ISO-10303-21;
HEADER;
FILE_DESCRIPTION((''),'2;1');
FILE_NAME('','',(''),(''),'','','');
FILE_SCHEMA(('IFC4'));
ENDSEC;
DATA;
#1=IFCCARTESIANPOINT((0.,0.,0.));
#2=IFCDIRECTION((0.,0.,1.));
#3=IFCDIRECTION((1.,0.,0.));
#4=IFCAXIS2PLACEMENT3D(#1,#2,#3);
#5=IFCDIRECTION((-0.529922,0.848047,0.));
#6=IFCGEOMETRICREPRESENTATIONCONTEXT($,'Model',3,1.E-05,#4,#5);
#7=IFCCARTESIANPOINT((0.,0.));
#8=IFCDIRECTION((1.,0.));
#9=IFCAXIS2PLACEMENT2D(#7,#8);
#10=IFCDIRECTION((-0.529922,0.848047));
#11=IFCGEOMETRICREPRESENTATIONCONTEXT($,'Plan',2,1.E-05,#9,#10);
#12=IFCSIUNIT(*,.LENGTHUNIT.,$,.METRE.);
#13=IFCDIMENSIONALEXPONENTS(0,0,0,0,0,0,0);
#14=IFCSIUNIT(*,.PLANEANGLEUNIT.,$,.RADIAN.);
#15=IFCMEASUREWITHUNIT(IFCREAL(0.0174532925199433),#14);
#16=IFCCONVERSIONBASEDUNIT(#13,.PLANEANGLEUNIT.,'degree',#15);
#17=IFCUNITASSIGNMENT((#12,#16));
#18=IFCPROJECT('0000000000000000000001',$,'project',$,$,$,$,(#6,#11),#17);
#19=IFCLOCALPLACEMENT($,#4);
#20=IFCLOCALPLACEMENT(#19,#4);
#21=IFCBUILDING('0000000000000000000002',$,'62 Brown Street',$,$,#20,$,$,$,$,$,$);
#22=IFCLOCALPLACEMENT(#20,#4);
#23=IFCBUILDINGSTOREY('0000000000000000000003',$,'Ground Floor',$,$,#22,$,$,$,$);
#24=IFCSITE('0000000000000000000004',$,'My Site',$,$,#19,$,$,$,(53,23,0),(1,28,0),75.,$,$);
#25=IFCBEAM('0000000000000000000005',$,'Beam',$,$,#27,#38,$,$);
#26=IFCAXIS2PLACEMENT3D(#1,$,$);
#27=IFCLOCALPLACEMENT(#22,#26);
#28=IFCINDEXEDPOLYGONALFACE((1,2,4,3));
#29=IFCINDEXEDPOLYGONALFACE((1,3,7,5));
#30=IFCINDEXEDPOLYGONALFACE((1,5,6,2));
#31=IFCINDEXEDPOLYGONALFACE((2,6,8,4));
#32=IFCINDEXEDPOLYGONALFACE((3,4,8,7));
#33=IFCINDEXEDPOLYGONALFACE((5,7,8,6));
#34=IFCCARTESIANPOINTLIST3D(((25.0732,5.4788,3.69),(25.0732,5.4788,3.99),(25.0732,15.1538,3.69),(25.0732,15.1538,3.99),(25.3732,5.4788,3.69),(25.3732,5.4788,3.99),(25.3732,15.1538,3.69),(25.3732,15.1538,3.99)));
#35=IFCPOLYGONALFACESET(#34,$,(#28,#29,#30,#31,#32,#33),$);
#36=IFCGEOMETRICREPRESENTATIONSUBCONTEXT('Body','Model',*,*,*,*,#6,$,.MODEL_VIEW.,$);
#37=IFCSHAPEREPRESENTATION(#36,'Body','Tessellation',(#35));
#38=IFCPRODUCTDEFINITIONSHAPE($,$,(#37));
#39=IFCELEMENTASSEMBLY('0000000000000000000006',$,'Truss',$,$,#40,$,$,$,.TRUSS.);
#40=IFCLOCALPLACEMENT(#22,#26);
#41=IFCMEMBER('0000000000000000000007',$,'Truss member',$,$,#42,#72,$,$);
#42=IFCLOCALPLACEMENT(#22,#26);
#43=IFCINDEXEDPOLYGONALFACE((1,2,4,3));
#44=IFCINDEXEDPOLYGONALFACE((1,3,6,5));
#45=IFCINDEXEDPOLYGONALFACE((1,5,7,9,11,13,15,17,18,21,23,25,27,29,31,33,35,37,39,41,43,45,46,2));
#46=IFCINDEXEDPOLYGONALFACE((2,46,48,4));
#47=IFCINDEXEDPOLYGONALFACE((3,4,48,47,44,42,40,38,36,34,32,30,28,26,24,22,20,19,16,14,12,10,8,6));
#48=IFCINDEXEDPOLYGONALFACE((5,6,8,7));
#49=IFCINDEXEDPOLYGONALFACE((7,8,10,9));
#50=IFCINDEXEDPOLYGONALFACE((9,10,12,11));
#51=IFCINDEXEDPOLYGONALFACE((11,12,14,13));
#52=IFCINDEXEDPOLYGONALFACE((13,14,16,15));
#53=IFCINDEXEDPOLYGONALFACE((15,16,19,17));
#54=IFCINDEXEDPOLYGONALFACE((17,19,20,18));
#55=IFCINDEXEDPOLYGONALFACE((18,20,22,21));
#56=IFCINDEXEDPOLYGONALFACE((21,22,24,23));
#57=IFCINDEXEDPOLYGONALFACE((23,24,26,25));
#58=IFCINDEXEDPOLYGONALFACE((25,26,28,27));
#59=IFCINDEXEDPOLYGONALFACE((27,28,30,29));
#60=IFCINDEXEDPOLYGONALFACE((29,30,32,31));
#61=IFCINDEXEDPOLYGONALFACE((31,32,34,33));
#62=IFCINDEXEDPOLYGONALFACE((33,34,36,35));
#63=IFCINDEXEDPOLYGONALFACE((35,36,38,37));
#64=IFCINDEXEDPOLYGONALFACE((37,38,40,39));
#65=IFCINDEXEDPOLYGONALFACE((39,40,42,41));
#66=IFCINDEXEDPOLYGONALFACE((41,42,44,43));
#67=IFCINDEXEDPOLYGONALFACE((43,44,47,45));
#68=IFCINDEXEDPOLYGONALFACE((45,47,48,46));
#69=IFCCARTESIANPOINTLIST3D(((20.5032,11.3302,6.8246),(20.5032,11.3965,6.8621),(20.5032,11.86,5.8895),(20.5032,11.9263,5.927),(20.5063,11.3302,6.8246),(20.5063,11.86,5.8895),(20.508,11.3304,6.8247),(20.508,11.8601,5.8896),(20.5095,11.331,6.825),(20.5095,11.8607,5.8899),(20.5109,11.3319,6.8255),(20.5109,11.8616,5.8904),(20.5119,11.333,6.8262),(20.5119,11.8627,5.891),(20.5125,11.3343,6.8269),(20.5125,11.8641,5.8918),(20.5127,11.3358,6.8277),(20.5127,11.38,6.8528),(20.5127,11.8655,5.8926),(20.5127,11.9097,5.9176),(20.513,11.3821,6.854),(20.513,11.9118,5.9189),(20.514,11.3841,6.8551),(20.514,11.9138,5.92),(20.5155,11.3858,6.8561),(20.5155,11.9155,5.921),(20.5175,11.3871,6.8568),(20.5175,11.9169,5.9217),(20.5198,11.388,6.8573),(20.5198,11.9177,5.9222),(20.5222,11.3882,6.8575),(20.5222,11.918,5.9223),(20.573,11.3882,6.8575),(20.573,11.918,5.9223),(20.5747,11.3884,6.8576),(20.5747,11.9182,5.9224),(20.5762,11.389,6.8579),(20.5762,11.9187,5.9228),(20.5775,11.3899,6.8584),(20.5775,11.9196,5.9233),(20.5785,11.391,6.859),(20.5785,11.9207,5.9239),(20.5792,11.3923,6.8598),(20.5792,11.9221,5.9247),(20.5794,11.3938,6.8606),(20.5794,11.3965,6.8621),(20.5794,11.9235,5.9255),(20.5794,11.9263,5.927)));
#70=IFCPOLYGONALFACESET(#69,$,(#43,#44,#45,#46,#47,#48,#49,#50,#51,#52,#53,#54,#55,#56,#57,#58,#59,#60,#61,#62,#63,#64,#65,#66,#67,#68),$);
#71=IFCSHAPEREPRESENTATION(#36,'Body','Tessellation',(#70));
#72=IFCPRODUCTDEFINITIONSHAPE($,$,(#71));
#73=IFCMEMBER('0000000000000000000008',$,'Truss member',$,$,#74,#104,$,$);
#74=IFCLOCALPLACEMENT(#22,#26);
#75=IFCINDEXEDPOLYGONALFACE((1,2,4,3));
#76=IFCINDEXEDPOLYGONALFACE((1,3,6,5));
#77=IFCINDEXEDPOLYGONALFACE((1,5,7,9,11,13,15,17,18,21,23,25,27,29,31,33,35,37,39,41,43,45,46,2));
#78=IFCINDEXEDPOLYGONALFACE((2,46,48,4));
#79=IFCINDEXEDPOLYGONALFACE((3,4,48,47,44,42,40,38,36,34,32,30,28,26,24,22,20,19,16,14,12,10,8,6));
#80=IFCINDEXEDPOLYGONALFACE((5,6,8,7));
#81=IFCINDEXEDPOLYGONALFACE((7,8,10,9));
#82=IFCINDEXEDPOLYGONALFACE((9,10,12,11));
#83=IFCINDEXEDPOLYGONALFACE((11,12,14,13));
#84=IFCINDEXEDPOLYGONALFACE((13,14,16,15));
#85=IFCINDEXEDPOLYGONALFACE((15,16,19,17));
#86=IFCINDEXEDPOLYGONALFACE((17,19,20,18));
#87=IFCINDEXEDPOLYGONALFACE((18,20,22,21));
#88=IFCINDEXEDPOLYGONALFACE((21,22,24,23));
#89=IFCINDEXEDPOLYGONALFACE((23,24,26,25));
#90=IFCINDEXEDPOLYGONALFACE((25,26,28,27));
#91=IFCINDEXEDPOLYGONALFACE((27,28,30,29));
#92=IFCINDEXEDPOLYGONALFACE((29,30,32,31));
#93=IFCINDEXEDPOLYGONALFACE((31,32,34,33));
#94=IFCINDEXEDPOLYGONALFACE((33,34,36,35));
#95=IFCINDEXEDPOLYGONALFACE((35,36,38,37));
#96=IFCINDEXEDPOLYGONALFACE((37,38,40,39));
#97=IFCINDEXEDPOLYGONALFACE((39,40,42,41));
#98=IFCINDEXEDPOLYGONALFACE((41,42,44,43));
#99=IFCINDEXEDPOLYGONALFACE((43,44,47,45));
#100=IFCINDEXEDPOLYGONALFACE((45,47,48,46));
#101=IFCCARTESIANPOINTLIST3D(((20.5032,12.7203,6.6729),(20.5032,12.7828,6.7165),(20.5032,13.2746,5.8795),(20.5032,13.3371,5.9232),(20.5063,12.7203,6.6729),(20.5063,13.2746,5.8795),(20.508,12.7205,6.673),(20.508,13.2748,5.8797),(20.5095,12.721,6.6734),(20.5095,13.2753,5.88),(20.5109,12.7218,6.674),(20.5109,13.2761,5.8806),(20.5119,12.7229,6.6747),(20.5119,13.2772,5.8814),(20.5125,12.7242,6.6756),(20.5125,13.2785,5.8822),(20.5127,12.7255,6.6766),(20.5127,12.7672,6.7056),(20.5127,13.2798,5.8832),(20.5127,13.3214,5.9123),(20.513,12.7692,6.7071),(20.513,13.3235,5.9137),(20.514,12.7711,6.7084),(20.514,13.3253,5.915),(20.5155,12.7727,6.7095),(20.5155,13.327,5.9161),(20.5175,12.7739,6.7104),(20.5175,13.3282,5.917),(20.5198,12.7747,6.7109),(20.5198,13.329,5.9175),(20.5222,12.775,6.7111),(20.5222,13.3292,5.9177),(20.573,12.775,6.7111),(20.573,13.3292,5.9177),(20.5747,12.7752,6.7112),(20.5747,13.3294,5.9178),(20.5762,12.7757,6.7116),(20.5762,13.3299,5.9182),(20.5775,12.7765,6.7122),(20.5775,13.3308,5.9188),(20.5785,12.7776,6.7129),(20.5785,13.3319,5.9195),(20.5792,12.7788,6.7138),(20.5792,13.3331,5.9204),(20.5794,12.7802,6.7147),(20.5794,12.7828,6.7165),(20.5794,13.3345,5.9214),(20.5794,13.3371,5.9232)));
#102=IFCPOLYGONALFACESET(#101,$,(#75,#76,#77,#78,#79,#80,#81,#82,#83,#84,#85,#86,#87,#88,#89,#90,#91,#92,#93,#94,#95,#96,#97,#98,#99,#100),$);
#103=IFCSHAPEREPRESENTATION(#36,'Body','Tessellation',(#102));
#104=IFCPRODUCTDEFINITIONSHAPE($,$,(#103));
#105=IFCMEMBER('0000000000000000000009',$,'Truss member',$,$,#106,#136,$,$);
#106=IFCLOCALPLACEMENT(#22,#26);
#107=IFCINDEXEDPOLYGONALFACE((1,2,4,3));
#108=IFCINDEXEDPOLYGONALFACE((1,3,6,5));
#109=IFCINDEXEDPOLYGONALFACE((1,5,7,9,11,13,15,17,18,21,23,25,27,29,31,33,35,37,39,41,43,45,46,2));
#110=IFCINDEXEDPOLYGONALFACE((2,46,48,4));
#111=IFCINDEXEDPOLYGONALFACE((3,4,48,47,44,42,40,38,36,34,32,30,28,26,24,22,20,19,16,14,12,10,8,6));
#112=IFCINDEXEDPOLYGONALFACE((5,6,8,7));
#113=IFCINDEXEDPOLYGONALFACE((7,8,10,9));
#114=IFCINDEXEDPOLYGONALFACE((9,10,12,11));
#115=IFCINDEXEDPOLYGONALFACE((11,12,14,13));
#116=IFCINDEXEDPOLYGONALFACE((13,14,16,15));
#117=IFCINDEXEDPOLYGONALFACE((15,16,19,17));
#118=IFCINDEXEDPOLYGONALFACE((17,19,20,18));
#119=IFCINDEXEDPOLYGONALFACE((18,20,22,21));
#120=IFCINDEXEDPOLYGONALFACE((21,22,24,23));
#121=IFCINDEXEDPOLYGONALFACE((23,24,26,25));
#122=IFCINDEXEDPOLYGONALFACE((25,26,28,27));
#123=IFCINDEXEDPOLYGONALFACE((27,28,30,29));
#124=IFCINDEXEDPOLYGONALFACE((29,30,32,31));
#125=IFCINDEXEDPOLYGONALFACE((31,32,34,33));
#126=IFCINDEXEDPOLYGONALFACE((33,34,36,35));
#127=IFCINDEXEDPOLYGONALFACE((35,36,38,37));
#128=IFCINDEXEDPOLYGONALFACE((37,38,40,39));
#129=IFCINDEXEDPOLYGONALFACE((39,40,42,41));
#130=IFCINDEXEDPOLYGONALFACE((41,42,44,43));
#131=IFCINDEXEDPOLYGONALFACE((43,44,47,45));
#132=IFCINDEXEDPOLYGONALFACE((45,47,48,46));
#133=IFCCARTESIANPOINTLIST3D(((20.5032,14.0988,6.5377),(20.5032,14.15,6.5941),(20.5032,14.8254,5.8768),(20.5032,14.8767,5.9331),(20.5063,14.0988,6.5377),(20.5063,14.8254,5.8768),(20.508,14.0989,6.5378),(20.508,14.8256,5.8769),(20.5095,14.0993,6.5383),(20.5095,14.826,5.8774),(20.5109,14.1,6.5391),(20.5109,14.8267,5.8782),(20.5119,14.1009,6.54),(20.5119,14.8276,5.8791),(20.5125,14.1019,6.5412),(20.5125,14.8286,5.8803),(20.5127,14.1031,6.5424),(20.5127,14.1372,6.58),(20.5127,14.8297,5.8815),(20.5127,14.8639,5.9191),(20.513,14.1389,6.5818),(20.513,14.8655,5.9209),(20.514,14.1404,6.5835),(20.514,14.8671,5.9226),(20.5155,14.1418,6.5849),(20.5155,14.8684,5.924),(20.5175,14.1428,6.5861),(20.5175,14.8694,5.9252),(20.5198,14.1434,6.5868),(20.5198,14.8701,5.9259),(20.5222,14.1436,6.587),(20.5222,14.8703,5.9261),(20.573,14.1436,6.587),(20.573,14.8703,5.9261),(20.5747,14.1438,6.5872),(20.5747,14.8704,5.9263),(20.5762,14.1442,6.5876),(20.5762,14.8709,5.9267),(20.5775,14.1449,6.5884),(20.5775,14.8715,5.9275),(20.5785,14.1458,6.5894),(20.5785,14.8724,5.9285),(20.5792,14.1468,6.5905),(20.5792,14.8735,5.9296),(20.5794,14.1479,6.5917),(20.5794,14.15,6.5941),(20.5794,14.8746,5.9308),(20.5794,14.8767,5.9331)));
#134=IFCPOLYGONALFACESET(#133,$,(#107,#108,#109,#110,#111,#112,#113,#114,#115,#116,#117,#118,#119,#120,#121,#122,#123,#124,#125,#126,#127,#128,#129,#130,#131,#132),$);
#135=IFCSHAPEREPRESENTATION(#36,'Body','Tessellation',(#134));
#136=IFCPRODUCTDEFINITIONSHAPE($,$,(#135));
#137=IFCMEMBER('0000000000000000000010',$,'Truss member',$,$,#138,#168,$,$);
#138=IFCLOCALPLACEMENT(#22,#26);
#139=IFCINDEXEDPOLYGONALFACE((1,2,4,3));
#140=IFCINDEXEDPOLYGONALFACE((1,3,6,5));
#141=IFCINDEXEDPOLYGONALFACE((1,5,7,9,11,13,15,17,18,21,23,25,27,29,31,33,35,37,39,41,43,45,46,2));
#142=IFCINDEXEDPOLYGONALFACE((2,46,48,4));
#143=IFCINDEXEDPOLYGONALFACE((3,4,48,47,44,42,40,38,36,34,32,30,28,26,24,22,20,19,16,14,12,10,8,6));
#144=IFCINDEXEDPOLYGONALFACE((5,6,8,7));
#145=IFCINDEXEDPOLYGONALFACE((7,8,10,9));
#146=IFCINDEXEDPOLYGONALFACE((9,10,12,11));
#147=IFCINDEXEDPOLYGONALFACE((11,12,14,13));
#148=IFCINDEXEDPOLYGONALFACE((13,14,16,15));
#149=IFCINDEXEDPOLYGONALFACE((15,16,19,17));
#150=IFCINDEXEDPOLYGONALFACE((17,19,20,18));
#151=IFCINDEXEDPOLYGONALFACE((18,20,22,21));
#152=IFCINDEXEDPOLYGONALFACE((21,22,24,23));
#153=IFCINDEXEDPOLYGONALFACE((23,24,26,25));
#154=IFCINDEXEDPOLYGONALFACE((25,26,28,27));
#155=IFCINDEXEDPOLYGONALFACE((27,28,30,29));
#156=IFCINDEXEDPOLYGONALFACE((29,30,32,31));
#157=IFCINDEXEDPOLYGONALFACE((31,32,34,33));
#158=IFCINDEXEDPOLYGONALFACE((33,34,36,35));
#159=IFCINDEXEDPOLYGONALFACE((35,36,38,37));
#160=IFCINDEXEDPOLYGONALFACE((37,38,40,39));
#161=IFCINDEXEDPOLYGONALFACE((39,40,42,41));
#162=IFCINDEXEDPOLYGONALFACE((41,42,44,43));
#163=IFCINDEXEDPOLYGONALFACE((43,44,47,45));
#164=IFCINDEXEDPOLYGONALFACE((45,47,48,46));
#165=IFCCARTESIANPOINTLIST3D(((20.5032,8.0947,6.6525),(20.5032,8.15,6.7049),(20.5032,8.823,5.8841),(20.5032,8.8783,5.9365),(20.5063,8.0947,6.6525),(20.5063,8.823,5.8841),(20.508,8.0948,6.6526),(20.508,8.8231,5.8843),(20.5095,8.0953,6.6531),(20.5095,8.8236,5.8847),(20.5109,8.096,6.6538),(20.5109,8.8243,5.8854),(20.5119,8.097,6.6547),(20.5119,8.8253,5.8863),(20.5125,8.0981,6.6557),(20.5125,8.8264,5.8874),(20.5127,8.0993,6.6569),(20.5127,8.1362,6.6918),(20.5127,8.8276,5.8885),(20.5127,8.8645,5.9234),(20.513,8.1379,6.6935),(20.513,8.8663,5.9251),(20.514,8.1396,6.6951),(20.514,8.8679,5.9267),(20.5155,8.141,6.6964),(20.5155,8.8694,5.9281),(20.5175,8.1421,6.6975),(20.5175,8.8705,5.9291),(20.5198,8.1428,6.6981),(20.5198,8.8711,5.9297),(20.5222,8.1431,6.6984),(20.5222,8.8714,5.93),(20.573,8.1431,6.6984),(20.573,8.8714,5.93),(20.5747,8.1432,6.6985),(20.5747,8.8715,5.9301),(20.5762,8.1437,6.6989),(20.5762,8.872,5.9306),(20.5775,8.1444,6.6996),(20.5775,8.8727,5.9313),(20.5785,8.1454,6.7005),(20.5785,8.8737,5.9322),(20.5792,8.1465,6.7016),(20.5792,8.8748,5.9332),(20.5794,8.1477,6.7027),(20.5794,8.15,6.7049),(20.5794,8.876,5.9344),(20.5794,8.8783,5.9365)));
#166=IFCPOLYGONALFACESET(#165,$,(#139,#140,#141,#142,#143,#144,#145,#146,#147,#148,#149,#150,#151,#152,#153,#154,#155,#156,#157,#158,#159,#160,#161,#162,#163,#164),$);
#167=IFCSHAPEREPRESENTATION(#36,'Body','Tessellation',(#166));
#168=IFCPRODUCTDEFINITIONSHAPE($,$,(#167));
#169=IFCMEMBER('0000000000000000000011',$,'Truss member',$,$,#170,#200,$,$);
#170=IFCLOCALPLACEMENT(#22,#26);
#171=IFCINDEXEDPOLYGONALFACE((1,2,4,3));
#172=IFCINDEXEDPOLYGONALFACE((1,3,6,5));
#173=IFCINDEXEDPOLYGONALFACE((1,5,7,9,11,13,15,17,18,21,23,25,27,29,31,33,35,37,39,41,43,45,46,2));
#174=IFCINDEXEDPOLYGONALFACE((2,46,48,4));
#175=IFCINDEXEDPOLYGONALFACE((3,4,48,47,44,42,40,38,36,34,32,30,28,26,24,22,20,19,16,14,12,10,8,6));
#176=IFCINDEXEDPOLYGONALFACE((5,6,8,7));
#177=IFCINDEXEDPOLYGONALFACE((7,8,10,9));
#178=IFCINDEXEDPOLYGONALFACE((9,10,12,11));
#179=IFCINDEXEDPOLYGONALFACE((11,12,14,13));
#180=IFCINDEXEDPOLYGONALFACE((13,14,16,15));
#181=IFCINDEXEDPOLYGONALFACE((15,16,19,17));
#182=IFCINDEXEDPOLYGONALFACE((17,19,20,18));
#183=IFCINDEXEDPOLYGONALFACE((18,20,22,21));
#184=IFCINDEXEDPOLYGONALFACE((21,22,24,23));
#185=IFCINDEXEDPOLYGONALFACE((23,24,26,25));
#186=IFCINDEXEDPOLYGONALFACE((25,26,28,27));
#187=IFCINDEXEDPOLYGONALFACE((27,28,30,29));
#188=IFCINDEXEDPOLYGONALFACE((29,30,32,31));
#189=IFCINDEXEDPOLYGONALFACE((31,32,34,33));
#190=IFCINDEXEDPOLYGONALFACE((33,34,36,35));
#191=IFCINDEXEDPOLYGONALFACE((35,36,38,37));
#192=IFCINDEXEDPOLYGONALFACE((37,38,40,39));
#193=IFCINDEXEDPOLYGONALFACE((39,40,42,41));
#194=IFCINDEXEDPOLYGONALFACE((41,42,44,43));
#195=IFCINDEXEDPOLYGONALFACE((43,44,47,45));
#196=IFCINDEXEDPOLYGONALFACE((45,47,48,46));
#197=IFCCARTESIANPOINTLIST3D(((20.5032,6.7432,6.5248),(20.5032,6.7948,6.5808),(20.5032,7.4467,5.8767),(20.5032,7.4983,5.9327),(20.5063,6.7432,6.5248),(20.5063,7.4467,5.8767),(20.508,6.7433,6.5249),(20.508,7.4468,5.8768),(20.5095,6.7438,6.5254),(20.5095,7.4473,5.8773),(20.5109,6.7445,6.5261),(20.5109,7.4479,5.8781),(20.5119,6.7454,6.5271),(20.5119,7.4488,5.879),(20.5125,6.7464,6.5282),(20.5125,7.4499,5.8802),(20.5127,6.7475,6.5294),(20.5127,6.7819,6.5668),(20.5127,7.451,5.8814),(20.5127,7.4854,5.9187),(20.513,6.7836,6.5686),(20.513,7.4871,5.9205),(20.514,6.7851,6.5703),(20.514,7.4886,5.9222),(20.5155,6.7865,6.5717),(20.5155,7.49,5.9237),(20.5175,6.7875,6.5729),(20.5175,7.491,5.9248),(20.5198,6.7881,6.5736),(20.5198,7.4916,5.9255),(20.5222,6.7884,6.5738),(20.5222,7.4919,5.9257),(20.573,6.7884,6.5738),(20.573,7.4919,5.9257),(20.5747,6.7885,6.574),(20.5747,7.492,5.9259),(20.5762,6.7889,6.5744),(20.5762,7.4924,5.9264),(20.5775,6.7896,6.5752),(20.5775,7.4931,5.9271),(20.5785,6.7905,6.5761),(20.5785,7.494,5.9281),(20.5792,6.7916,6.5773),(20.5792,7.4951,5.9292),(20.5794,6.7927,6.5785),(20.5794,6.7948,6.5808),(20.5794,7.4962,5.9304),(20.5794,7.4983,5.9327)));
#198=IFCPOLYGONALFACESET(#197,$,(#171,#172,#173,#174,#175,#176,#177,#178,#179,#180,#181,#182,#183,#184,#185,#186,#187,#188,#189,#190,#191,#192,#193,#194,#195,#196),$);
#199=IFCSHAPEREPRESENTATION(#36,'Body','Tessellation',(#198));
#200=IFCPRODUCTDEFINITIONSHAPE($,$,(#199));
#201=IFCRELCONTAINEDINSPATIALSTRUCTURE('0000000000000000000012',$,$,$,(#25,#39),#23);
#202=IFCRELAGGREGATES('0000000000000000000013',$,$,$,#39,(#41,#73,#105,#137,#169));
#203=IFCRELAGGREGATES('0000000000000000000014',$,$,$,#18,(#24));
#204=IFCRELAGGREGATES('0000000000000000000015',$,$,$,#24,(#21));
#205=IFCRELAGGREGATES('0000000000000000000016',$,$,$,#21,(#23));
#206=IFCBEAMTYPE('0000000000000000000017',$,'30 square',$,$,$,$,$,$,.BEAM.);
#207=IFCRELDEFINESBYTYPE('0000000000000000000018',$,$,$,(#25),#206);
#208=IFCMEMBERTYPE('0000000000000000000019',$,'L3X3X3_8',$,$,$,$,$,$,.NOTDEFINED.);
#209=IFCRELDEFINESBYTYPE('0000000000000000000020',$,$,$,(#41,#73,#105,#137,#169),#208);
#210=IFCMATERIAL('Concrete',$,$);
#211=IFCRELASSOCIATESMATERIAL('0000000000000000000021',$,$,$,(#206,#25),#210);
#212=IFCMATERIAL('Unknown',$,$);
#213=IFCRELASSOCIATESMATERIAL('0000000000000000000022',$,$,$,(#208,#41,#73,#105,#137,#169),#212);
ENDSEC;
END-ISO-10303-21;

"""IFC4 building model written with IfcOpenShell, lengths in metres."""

from ifc_helpers import new_model, entity, si_unit, converted_unit, direction, frame, origin_with_axes, origin_2d_with_axis, place, context, subcontext, project, spatial, rectangle, l_section, extrude, material, material_profile, profile_set, profile_usage, type_object, element, aggregate, save


model = new_model("IFC4")

# Units and contexts
model_context = context("Model", 3, precision=1e-05, world=origin_with_axes(), true_north=direction((-0.529922, 0.848047, 0.0)))
plan_context = context("Plan", 2, precision=1e-05, world=origin_2d_with_axis(), true_north=direction((-0.529922, 0.848047)))
body_context = subcontext(model_context, "Body", "Model", "MODEL_VIEW")
ifc_project = project(units=[si_unit("LENGTHUNIT", "METRE"), converted_unit("PLANEANGLEUNIT", "degree", entity("IfcReal", 0.0174532925199433), si_unit("PLANEANGLEUNIT", "RADIAN"), dimensions=[0, 0, 0, 0, 0, 0, 0])], contexts=[model_context, plan_context])

# Site, building, storey
site_placement = place(None, origin_with_axes())
site = spatial("IfcSite", under=ifc_project, at=site_placement, Name="My Site", RefLatitude=(53, 23, 0), RefLongitude=(1, 28, 0), RefElevation=75.0)
building_placement = place(site_placement, origin_with_axes())
building = spatial("IfcBuilding", under=site, at=building_placement, Name="62 Brown Street")
storey_placement = place(building_placement, origin_with_axes())
storey = spatial("IfcBuildingStorey", under=building, at=storey_placement, Name="Ground Floor")

# Shared definitions
ifc_material_1 = material(Name="Concrete")

# Beam
ifc_material_profile_1 = material_profile(ifc_material_1, rectangle(XDim=0.3, YDim=0.3))
ifc_profile_set_1 = profile_set([ifc_material_profile_1])
ifc_profile_usage_1 = profile_usage(ifc_profile_set_1, cardinal=5)
beam_type = type_object("IfcBeamType", Name="30 square", PredefinedType="BEAM", material=ifc_profile_set_1)
beam_placement = place(storey_placement, frame((25.2232, 5.4788, 3.84), z_axis=(0.0, 1.0, 0.0), x_axis=(-1.0, 0.0, 0.0)))
element("IfcBeam", 1, at=beam_placement, inside=storey, type_object=beam_type, material=ifc_profile_usage_1, Name="Beam", context=body_context, shape_type="SweptSolid", body=[
    extrude(rectangle(XDim=0.3, YDim=0.3), origin_with_axes(), (0.0, 0.0, 1.0), 9.675),
])

# Element assembly, members
assembly_placement = place(storey_placement, frame((20.5032, 10.4288, 6.9738), z_axis=(0.0, 0.0, 1.0), x_axis=(1.0, 0.0, 0.0)))
assembly = element("IfcElementAssembly", 2, at=assembly_placement, inside=storey, Name="Truss", PredefinedType="TRUSS")
ifc_material_2 = material(Name="Unknown")
ifc_material_profile_2 = material_profile(ifc_material_2, l_section(Depth=0.0762, Width=0.0762, Thickness=0.0095, FilletRadius=0.0095, EdgeRadius=0.0064))
ifc_profile_set_2 = profile_set([ifc_material_profile_2])
ifc_profile_usage_2 = profile_usage(ifc_profile_set_2, cardinal=5)
member_type_1 = type_object("IfcMemberType", Name="L3X3X3_8", PredefinedType="NOTDEFINED", material=ifc_profile_set_2)
member_1_placement = place(assembly_placement, frame((0.0381, 0.9346, -0.1304), z_axis=(0.0, 0.492899, -0.870086), x_axis=(1.0, 0.0, 0.0)))
member_1 = element("IfcMember", 3, at=member_1_placement, type_object=member_type_1, material=ifc_profile_usage_2, Name="Truss member", context=body_context, shape_type="SweptSolid", body=[
    extrude(l_section(Depth=0.0762, Width=0.0762, Thickness=0.0095, FilletRadius=0.0095, EdgeRadius=0.0064), origin_with_axes(), (0.0, 0.0, 1.0), 1.0747),
])
ifc_profile_usage_3 = profile_usage(ifc_profile_set_2, cardinal=5)
member_2_placement = place(assembly_placement, frame((0.0381, 2.3228, -0.279), z_axis=(-0.000001, 0.572709, -0.819759), x_axis=(1.0, 0.0, 0.0)))
member_2 = element("IfcMember", 4, at=member_2_placement, type_object=member_type_1, material=ifc_profile_usage_3, Name="Truss member", context=body_context, shape_type="SweptSolid", body=[
    extrude(l_section(Depth=0.0762, Width=0.0762, Thickness=0.0095, FilletRadius=0.0095, EdgeRadius=0.0064), origin_with_axes(), (0.0, 0.0, 1.0), 0.9678),
])
ifc_profile_usage_4 = profile_usage(ifc_profile_set_2, cardinal=5)
member_3_placement = place(assembly_placement, frame((0.0381, 3.6956, -0.4079), z_axis=(-0.000001, 0.739785, -0.672843), x_axis=(1.0, 0.000001, 0.0)))
member_3 = element("IfcMember", 5, at=member_3_placement, type_object=member_type_1, material=ifc_profile_usage_4, Name="Truss member", context=body_context, shape_type="SweptSolid", body=[
    extrude(l_section(Depth=0.0762, Width=0.0762, Thickness=0.0095, FilletRadius=0.0095, EdgeRadius=0.0064), origin_with_axes(), (0.0, 0.0, 1.0), 0.9823),
])
ifc_profile_usage_5 = profile_usage(ifc_profile_set_2, cardinal=5)
member_4_placement = place(assembly_placement, frame((0.0381, -2.3065, -0.2951), z_axis=(-0.000001, 0.687927, -0.72578), x_axis=(1.0, 0.0, 0.0)))
member_4 = element("IfcMember", 6, at=member_4_placement, type_object=member_type_1, material=ifc_profile_usage_5, Name="Truss member", context=body_context, shape_type="SweptSolid", body=[
    extrude(l_section(Depth=0.0762, Width=0.0762, Thickness=0.0095, FilletRadius=0.0095, EdgeRadius=0.0064), origin_with_axes(), (0.0, 0.0, 1.0), 1.0587),
])
ifc_profile_usage_6 = profile_usage(ifc_profile_set_2, cardinal=5)
member_5_placement = place(assembly_placement, frame((0.0381, -3.6598, -0.421), z_axis=(-0.000001, 0.735484, -0.677542), x_axis=(1.0, 0.000001, 0.0)))
member_5 = element("IfcMember", 7, at=member_5_placement, type_object=member_type_1, material=ifc_profile_usage_6, Name="Truss member", context=body_context, shape_type="SweptSolid", body=[
    extrude(l_section(Depth=0.0762, Width=0.0762, Thickness=0.0095, FilletRadius=0.0095, EdgeRadius=0.0064), origin_with_axes(), (0.0, 0.0, 1.0), 0.9565),
])
aggregate(assembly, [member_1, member_2, member_3, member_4, member_5])

save(model, "model.ifc")
